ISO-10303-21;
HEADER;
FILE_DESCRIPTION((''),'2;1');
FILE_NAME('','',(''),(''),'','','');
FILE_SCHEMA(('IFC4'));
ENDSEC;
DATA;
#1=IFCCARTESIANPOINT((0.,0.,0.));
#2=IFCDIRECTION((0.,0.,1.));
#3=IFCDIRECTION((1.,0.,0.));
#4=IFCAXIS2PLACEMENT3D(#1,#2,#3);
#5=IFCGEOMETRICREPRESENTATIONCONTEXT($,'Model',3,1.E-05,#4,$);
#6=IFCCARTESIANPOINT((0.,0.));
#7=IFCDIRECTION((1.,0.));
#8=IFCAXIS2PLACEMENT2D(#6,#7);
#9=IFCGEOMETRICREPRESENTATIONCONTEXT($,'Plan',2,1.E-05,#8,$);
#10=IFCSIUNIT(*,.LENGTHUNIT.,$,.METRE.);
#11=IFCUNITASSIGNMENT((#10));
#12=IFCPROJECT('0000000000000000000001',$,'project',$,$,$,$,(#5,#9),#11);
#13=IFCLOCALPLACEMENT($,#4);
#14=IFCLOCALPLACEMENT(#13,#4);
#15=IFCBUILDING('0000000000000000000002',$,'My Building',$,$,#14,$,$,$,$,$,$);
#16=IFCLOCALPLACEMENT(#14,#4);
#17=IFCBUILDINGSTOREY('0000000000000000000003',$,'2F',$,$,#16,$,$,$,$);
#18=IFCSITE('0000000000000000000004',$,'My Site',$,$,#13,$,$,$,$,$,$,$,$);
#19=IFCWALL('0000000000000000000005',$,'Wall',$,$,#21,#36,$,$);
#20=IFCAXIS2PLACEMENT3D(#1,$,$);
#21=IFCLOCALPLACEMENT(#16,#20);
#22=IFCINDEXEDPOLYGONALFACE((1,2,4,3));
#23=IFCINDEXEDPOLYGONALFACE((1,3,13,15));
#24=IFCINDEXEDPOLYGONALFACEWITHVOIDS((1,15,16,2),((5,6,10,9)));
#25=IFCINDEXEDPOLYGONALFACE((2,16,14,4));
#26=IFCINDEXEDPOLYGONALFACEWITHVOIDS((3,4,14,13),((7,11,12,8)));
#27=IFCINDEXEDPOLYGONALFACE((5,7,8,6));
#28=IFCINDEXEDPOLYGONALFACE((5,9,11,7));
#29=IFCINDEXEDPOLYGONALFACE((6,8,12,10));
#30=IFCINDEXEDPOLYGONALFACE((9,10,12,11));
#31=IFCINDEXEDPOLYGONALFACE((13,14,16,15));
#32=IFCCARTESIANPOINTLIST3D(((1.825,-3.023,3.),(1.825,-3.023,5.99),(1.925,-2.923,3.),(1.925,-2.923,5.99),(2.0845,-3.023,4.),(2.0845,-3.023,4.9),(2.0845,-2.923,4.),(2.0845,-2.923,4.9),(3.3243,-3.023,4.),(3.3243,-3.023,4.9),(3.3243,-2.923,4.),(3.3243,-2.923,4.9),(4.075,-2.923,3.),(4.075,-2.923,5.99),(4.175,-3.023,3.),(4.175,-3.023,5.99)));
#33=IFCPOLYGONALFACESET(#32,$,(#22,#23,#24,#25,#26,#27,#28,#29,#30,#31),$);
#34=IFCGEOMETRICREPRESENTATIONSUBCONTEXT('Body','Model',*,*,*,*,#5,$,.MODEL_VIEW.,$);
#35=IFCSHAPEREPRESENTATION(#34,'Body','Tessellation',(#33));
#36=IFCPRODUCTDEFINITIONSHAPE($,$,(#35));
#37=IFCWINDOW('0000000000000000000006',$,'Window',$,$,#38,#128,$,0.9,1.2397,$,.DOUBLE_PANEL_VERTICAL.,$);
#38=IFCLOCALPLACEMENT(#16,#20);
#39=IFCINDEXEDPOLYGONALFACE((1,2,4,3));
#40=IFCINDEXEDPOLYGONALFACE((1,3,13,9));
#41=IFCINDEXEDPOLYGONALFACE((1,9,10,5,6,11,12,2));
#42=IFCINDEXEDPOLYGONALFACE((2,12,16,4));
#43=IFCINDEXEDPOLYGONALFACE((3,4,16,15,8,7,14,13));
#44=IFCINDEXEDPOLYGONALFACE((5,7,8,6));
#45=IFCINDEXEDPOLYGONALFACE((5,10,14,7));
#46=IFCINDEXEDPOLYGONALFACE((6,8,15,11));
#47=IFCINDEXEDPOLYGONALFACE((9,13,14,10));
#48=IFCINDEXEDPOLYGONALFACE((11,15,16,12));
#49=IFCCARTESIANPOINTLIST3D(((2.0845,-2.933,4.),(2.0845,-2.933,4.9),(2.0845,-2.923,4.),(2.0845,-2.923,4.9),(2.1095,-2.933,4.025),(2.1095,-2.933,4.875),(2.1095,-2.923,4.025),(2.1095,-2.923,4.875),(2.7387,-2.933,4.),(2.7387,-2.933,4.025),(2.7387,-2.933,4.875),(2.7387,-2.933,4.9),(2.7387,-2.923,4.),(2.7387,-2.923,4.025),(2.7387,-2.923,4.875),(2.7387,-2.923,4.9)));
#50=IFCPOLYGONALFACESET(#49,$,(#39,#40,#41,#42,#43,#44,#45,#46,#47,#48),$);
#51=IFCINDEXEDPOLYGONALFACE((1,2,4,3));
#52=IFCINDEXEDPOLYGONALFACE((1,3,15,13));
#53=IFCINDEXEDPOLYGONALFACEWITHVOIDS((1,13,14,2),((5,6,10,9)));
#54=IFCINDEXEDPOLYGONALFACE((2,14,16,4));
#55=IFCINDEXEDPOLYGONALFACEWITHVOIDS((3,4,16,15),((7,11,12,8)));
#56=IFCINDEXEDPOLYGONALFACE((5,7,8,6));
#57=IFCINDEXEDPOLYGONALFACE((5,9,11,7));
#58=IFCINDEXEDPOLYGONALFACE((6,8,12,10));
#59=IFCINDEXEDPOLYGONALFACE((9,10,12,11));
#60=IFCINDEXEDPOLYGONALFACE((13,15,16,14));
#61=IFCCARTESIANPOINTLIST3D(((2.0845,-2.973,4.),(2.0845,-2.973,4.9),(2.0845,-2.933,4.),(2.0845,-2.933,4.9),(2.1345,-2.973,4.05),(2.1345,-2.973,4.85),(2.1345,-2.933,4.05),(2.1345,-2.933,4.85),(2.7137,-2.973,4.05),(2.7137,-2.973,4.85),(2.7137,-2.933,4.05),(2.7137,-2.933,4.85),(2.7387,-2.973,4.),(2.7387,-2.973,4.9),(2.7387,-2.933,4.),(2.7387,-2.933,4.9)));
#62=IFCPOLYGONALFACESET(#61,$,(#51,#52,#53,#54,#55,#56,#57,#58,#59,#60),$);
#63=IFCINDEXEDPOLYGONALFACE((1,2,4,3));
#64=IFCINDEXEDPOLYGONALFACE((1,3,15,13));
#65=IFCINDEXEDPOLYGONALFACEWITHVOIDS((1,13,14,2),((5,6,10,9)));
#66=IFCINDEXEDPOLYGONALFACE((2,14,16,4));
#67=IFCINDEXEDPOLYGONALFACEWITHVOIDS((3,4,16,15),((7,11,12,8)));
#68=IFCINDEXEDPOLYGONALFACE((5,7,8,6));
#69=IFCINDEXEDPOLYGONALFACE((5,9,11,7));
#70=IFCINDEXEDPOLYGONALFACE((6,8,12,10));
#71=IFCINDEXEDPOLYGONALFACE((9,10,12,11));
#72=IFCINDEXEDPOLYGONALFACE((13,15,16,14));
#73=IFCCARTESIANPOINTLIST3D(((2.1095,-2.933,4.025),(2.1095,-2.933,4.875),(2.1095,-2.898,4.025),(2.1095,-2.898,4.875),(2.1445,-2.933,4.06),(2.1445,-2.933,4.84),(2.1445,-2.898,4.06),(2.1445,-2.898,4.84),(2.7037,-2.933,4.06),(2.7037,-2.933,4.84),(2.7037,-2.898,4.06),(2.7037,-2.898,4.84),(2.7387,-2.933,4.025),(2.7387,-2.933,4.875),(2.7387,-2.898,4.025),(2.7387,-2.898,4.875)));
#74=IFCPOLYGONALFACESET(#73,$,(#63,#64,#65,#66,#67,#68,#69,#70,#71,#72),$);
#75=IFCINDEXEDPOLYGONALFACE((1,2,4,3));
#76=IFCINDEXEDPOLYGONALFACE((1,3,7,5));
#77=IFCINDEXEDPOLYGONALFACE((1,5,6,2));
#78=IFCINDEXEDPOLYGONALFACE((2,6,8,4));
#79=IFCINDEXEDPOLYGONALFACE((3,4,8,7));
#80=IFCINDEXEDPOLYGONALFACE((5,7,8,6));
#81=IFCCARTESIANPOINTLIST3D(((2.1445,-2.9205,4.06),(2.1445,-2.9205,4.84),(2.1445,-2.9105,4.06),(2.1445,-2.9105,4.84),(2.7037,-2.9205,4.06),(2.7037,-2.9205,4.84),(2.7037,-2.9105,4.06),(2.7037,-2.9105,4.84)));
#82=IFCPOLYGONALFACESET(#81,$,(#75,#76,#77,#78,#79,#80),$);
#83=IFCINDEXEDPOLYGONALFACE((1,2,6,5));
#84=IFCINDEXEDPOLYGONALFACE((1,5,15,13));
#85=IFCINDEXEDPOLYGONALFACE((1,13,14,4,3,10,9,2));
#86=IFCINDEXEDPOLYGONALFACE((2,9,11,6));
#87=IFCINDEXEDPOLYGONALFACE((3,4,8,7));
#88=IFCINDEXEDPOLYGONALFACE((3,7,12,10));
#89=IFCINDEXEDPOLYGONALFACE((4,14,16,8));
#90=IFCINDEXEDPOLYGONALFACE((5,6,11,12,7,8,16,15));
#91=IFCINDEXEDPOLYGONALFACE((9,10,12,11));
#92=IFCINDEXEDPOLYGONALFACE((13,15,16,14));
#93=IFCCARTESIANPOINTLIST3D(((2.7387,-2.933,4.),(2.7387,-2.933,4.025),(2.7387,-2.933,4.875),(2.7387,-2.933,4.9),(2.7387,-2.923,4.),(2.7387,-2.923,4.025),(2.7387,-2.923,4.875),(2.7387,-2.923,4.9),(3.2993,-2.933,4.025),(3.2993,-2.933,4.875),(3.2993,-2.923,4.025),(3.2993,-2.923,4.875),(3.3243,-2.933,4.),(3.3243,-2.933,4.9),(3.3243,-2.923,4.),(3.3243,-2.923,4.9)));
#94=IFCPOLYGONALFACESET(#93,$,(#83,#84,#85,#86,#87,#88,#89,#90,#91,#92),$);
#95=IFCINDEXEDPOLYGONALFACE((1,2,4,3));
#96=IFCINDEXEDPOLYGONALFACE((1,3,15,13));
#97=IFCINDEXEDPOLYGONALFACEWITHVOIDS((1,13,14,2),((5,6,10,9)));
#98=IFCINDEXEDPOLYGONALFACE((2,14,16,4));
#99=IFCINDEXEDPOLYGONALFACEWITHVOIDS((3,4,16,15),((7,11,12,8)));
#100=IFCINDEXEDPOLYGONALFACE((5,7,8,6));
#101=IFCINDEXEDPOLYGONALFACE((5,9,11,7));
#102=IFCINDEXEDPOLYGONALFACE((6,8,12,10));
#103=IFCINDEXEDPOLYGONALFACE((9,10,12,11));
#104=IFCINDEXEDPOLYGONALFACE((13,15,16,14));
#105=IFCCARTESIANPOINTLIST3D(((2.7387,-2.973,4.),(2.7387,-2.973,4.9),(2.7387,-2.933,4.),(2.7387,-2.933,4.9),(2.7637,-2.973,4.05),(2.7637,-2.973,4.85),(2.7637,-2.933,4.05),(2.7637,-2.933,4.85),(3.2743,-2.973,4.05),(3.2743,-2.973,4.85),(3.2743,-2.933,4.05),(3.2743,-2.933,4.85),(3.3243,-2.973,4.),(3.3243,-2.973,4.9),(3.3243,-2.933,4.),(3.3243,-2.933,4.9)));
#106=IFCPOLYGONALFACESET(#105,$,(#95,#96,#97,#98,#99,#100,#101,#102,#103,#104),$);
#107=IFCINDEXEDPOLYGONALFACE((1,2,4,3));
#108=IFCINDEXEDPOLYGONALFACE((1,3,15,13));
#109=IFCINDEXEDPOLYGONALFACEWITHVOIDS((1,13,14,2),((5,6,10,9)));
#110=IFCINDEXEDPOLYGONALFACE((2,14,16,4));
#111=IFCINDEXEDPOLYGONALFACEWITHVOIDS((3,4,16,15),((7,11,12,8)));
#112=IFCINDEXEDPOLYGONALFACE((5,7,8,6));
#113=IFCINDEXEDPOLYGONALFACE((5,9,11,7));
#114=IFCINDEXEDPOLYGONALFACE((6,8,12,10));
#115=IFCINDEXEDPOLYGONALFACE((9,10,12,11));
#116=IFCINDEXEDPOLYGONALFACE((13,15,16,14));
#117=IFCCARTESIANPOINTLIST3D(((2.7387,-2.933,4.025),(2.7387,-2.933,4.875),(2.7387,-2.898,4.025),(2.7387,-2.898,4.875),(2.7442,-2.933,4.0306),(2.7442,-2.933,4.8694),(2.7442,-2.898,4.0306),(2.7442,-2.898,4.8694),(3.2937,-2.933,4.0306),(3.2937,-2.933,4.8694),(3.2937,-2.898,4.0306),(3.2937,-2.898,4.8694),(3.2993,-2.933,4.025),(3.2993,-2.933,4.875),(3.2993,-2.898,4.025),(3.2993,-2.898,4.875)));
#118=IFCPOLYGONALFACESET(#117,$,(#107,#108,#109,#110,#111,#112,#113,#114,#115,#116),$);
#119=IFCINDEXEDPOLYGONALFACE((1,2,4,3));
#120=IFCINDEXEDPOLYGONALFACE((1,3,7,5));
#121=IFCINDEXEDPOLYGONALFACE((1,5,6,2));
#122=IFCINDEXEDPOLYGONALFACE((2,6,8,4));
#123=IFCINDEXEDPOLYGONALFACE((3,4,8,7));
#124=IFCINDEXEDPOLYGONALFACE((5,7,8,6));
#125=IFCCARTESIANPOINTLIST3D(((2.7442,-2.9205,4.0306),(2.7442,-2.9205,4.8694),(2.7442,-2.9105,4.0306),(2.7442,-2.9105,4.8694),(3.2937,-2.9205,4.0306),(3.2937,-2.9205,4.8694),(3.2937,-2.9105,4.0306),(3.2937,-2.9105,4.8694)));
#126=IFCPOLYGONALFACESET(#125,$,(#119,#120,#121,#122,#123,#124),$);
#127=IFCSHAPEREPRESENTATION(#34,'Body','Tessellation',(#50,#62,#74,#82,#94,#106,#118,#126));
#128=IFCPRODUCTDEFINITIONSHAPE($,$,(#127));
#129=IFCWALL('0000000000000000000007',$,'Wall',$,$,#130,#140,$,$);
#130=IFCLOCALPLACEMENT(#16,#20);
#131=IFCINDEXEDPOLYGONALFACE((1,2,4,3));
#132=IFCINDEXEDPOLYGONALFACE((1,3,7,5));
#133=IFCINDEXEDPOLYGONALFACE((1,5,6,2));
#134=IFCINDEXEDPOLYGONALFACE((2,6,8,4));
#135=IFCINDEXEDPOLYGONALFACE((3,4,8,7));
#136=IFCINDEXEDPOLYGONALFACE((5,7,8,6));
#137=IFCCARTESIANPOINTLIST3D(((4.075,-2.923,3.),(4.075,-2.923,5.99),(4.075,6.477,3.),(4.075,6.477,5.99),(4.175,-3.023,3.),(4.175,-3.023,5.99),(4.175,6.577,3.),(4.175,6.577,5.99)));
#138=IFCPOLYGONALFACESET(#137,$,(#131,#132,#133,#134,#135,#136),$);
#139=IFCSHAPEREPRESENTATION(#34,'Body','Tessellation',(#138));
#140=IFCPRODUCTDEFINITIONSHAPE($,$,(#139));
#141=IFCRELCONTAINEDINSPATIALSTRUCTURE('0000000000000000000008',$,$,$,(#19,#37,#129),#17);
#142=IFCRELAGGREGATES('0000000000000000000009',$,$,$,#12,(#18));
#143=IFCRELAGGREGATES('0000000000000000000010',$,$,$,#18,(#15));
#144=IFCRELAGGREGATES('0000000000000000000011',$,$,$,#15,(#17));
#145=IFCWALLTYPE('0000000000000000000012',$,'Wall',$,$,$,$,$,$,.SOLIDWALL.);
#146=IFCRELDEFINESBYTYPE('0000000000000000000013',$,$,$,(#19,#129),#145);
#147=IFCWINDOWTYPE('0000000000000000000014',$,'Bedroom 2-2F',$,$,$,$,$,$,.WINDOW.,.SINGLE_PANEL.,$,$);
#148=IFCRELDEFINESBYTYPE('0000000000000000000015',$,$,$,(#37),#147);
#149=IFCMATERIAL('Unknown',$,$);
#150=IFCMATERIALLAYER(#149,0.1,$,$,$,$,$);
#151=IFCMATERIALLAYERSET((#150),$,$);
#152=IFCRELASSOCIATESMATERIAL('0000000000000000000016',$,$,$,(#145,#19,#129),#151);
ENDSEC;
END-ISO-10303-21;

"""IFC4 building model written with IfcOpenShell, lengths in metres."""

from ifc_helpers import new_model, entity, si_unit, frame, origin_with_axes, origin_2d_with_axis, place, context, subcontext, project, spatial, line, indexed_curve, outline, extrude, shape, source, transform, mapped, material, layer, layer_set, layer_usage, type_object, type_shapes, element, fill, save


model = new_model("IFC4")

# Units and contexts
model_context = context("Model", 3, precision=1e-05, world=origin_with_axes())
plan_context = context("Plan", 2, precision=1e-05, world=origin_2d_with_axis())
body_context_1 = subcontext(model_context, "Body", "Model", "MODEL_VIEW")
body_context_2 = subcontext(plan_context, "Body", "Plan", "PLAN_VIEW")
ifc_project = project(units=[si_unit("LENGTHUNIT", "METRE")], contexts=[model_context, plan_context])

# Site, building, storey
site_placement = place(None, origin_with_axes())
site = spatial("IfcSite", under=ifc_project, at=site_placement, Name="My Site")
building_placement = place(site_placement, origin_with_axes())
building = spatial("IfcBuilding", under=site, at=building_placement, Name="My Building")
storey_placement = place(building_placement, origin_with_axes())
storey = spatial("IfcBuildingStorey", under=building, at=storey_placement, Name="2F")

# Shared definitions
ifc_material = material(Name="Unknown")

# Shared definitions
ifc_layer_1 = layer(ifc_material, 0.1)
ifc_layer_set_1 = layer_set([ifc_layer_1])
wall_type = type_object("IfcWallType", Name="Wall", PredefinedType="SOLIDWALL", material=ifc_layer_set_1)

# Wall, opening, window
ifc_layer_usage_1 = layer_usage(ifc_layer_set_1, "AXIS2", "POSITIVE", 0.0)
wall_1_placement = place(storey_placement, frame((1.825, -3.023, 3.0), z_axis=(0.0, 0.0, 1.0), x_axis=(1.0, 0.0, 0.0)))
wall_1 = element("IfcWall", 1, at=wall_1_placement, inside=storey, type_object=wall_type, material=ifc_layer_usage_1, Name="Wall", context=body_context_1, shape_type="SweptSolid", body=[
    extrude(outline(indexed_curve([(0.0, 0.0), (0.1, 0.1), (2.25, 0.1), (2.35, 0.0)], segments=[line(1, 2, 3, 4, 1)])), origin_with_axes(), (0.0, 0.0, 1.0), 2.99),
])
shared_shape_1 = source(origin_with_axes(), body_context_1, "Body", "SweptSolid", [
    extrude(outline(indexed_curve([(0.0, 0.0), (1.2397, 0.0), (1.2397, 0.9), (0.0, 0.9)], segments=[line(1, 2, 3, 4, 1)])), frame((0.0, -0.6, 0.0), z_axis=(0.0, -1.0, 0.0), x_axis=(1.0, 0.0, 0.0)), (0.0, 0.0, -1.0), 1.2),
])
opening_1_placement = place(wall_1_placement, frame((0.2595, 0.0, 1.0), z_axis=(0.0, 0.0, 1.0), x_axis=(1.0, 0.0, 0.0)))
opening_1 = element("IfcOpeningElement", 2, at=opening_1_placement, cuts=wall_1, PredefinedType="OPENING", context=body_context_1, shape_type="MappedRepresentation", body=[
    mapped(shared_shape_1, transform((0.0, 0.0, 0.0), x_axis=(1.0, 0.0, 0.0), y_axis=(0.0, 1.0, 0.0), z_axis=(0.0, 0.0, 1.0), scale=1.0)),
])
window_type_1 = type_object("IfcWindowType", Name="Bedroom 2-2F", PartitioningType="SINGLE_PANEL", PredefinedType="WINDOW")
shared_shape_2 = source(origin_with_axes(), body_context_1, "Body", "SweptSolid", [
    extrude(outline(indexed_curve([(0.6541, 0.0), (0.0, 0.0), (0.0, 0.9), (0.6541, 0.9), (0.6541, 0.875), (0.025, 0.875), (0.025, 0.025), (0.6541, 0.025)], segments=[line(1, 2, 3, 4, 5, 6, 7, 8, 1)])), frame((0.0, 0.09, 0.0), z_axis=(0.0, -1.0, 0.0), x_axis=(1.0, 0.0, 0.0)), (0.0, 0.0, -1.0), 0.01),
    extrude(outline(indexed_curve([(0.0, 0.0), (0.6541, 0.0), (0.6541, 0.9), (0.0, 0.9)], segments=[line(1, 2, 3, 4, 1)]), holes=[indexed_curve([(0.05, 0.05), (0.6291, 0.05), (0.6291, 0.85), (0.05, 0.85)], segments=[line(1, 2, 3, 4, 1)])]), frame((0.0, 0.05, 0.0), z_axis=(0.0, -1.0, 0.0), x_axis=(1.0, 0.0, 0.0)), (0.0, 0.0, -1.0), 0.04),
    extrude(outline(indexed_curve([(0.0, 0.0), (0.6291, 0.0), (0.6291, 0.85), (0.0, 0.85)], segments=[line(1, 2, 3, 4, 1)]), holes=[indexed_curve([(0.035, 0.035), (0.5941, 0.035), (0.5941, 0.815), (0.035, 0.815)], segments=[line(1, 2, 3, 4, 1)])]), frame((0.025, 0.09, 0.025), z_axis=(0.0, -1.0, 0.0), x_axis=(1.0, 0.0, 0.0)), (0.0, 0.0, -1.0), 0.035),
    extrude(outline(indexed_curve([(0.035, 0.035), (0.5941, 0.035), (0.5941, 0.815), (0.035, 0.815)], segments=[line(1, 2, 3, 4, 1)])), frame((0.025, 0.1025, 0.025), z_axis=(0.0, -1.0, 0.0), x_axis=(1.0, 0.0, 0.0)), (0.0, 0.0, -1.0), 0.01),
    extrude(outline(indexed_curve([(0.0, 0.9), (0.5856, 0.9), (0.5856, 0.0), (0.0, 0.0), (0.0, 0.025), (0.5606, 0.025), (0.5606, 0.875), (0.0, 0.875)], segments=[line(1, 2, 3, 4, 5, 6, 7, 8, 1)])), frame((0.6541, 0.09, 0.0), z_axis=(0.0, -1.0, 0.0), x_axis=(1.0, 0.0, 0.0)), (0.0, 0.0, -1.0), 0.01),
    extrude(outline(indexed_curve([(0.0, 0.0), (0.5856, 0.0), (0.5856, 0.9), (0.0, 0.9)], segments=[line(1, 2, 3, 4, 1)]), holes=[indexed_curve([(0.025, 0.05), (0.5356, 0.05), (0.5356, 0.85), (0.025, 0.85)], segments=[line(1, 2, 3, 4, 1)])]), frame((0.6541, 0.05, 0.0), z_axis=(0.0, -1.0, 0.0), x_axis=(1.0, 0.0, 0.0)), (0.0, 0.0, -1.0), 0.04),
    extrude(outline(indexed_curve([(0.0, 0.0), (0.5606, 0.0), (0.5606, 0.85), (0.0, 0.85)], segments=[line(1, 2, 3, 4, 1)]), holes=[indexed_curve([(0.0056, 0.0056), (0.555, 0.0056), (0.555, 0.8444), (0.0056, 0.8444)], segments=[line(1, 2, 3, 4, 1)])]), frame((0.6541, 0.09, 0.025), z_axis=(0.0, -1.0, 0.0), x_axis=(1.0, 0.0, 0.0)), (0.0, 0.0, -1.0), 0.035),
    extrude(outline(indexed_curve([(0.0056, 0.0056), (0.555, 0.0056), (0.555, 0.8444), (0.0056, 0.8444)], segments=[line(1, 2, 3, 4, 1)])), frame((0.6541, 0.1025, 0.025), z_axis=(0.0, -1.0, 0.0), x_axis=(1.0, 0.0, 0.0)), (0.0, 0.0, -1.0), 0.01),
])
shared_shape_3 = source(origin_with_axes(), body_context_2, "Body", "Curve2D", [
    entity("IfcIndexedPolyCurve", entity("IfcCartesianPointList2D", [[0.05, 0.05], [0.6291, 0.05]])),
    entity("IfcIndexedPolyCurve", entity("IfcCartesianPointList2D", [[0.0, 0.1], [0.025, 0.1], [0.025, 0.09], [0.05, 0.09], [0.05, 0.05], [0.0, 0.05]]), [entity("IfcLineIndex", [1, 2, 3, 4, 5, 6, 1])]),
    entity("IfcIndexedPolyCurve", entity("IfcCartesianPointList2D", [[0.6541, 0.1], [0.6541, 0.1], [0.6541, 0.09], [0.6291, 0.09], [0.6291, 0.05], [0.6541, 0.05]])),
    entity("IfcIndexedPolyCurve", entity("IfcCartesianPointList2D", [[0.025, 0.09], [0.06, 0.09], [0.06, 0.125], [0.025, 0.125]]), [entity("IfcLineIndex", [1, 2, 3, 4, 1])]),
    entity("IfcIndexedPolyCurve", entity("IfcCartesianPointList2D", [[0.6541, 0.09], [0.6191, 0.09], [0.6191, 0.125], [0.6541, 0.125]]), [entity("IfcLineIndex", [1, 2, 3, 4, 1])]),
    entity("IfcIndexedPolyCurve", entity("IfcCartesianPointList2D", [[0.06, 0.09], [0.6191, 0.09]])),
    entity("IfcIndexedPolyCurve", entity("IfcCartesianPointList2D", [[0.06, 0.125], [0.6191, 0.125]])),
    entity("IfcIndexedPolyCurve", entity("IfcCartesianPointList2D", [[0.06, 0.1075], [0.6191, 0.1075]])),
    entity("IfcIndexedPolyCurve", entity("IfcCartesianPointList2D", [[0.6791, 0.05], [1.1897, 0.05]])),
    entity("IfcIndexedPolyCurve", entity("IfcCartesianPointList2D", [[0.6541, 0.1], [0.6541, 0.1], [0.6541, 0.09], [0.6791, 0.09], [0.6791, 0.05], [0.6541, 0.05]])),
    entity("IfcIndexedPolyCurve", entity("IfcCartesianPointList2D", [[1.2397, 0.1], [1.2147, 0.1], [1.2147, 0.09], [1.1897, 0.09], [1.1897, 0.05], [1.2397, 0.05]]), [entity("IfcLineIndex", [1, 2, 3, 4, 5, 6, 1])]),
    entity("IfcIndexedPolyCurve", entity("IfcCartesianPointList2D", [[0.6541, 0.09], [0.6597, 0.09], [0.6597, 0.125], [0.6541, 0.125]]), [entity("IfcLineIndex", [1, 2, 3, 4, 1])]),
    entity("IfcIndexedPolyCurve", entity("IfcCartesianPointList2D", [[1.2147, 0.09], [1.2092, 0.09], [1.2092, 0.125], [1.2147, 0.125]]), [entity("IfcLineIndex", [1, 2, 3, 4, 1])]),
    entity("IfcIndexedPolyCurve", entity("IfcCartesianPointList2D", [[0.6597, 0.09], [1.2092, 0.09]])),
    entity("IfcIndexedPolyCurve", entity("IfcCartesianPointList2D", [[0.6597, 0.125], [1.2092, 0.125]])),
    entity("IfcIndexedPolyCurve", entity("IfcCartesianPointList2D", [[0.6597, 0.1075], [1.2092, 0.1075]])),
])
type_shapes(window_type_1, [shared_shape_2, shared_shape_3])
window_1_placement = place(opening_1_placement, frame((0.0, 0.0, 0.0), z_axis=(0.0, 0.0, 1.0), x_axis=(1.0, 0.0, 0.0)))
window_1 = element("IfcWindow", 3, at=window_1_placement, inside=storey, type_object=window_type_1, Name="Window", OverallHeight=0.9, OverallWidth=1.2397, PartitioningType="DOUBLE_PANEL_VERTICAL", shapes=[
    shape(body_context_1, "Body", "MappedRepresentation", [mapped(shared_shape_2, transform((0.0, 0.0, 0.0), x_axis=(1.0, 0.0, 0.0), y_axis=(0.0, 1.0, 0.0), z_axis=(0.0, 0.0, 1.0), scale=1.0))]),
    shape(body_context_2, "Body", "MappedRepresentation", [mapped(shared_shape_3, transform((0.0, 0.0, 0.0), x_axis=(1.0, 0.0, 0.0), y_axis=(0.0, 1.0, 0.0), z_axis=(0.0, 0.0, 1.0), scale=1.0))]),
])
fill(opening_1, window_1)

# Wall
ifc_layer_usage_2 = layer_usage(ifc_layer_set_1, "AXIS2", "POSITIVE", 0.0)
wall_2_placement = place(storey_placement, frame((4.175, -3.023, 3.0), z_axis=(0.0, 0.0, 1.0), x_axis=(0.0, 1.0, 0.0)))
element("IfcWall", 4, at=wall_2_placement, inside=storey, type_object=wall_type, material=ifc_layer_usage_2, Name="Wall", context=body_context_1, shape_type="SweptSolid", body=[
    extrude(outline(indexed_curve([(0.0, 0.0), (0.1, 0.1), (9.5, 0.1), (9.6, 0.0)], segments=[line(1, 2, 3, 4, 1)])), origin_with_axes(), (0.0, 0.0, 1.0), 2.99),
])

save(model, "model.ifc")
